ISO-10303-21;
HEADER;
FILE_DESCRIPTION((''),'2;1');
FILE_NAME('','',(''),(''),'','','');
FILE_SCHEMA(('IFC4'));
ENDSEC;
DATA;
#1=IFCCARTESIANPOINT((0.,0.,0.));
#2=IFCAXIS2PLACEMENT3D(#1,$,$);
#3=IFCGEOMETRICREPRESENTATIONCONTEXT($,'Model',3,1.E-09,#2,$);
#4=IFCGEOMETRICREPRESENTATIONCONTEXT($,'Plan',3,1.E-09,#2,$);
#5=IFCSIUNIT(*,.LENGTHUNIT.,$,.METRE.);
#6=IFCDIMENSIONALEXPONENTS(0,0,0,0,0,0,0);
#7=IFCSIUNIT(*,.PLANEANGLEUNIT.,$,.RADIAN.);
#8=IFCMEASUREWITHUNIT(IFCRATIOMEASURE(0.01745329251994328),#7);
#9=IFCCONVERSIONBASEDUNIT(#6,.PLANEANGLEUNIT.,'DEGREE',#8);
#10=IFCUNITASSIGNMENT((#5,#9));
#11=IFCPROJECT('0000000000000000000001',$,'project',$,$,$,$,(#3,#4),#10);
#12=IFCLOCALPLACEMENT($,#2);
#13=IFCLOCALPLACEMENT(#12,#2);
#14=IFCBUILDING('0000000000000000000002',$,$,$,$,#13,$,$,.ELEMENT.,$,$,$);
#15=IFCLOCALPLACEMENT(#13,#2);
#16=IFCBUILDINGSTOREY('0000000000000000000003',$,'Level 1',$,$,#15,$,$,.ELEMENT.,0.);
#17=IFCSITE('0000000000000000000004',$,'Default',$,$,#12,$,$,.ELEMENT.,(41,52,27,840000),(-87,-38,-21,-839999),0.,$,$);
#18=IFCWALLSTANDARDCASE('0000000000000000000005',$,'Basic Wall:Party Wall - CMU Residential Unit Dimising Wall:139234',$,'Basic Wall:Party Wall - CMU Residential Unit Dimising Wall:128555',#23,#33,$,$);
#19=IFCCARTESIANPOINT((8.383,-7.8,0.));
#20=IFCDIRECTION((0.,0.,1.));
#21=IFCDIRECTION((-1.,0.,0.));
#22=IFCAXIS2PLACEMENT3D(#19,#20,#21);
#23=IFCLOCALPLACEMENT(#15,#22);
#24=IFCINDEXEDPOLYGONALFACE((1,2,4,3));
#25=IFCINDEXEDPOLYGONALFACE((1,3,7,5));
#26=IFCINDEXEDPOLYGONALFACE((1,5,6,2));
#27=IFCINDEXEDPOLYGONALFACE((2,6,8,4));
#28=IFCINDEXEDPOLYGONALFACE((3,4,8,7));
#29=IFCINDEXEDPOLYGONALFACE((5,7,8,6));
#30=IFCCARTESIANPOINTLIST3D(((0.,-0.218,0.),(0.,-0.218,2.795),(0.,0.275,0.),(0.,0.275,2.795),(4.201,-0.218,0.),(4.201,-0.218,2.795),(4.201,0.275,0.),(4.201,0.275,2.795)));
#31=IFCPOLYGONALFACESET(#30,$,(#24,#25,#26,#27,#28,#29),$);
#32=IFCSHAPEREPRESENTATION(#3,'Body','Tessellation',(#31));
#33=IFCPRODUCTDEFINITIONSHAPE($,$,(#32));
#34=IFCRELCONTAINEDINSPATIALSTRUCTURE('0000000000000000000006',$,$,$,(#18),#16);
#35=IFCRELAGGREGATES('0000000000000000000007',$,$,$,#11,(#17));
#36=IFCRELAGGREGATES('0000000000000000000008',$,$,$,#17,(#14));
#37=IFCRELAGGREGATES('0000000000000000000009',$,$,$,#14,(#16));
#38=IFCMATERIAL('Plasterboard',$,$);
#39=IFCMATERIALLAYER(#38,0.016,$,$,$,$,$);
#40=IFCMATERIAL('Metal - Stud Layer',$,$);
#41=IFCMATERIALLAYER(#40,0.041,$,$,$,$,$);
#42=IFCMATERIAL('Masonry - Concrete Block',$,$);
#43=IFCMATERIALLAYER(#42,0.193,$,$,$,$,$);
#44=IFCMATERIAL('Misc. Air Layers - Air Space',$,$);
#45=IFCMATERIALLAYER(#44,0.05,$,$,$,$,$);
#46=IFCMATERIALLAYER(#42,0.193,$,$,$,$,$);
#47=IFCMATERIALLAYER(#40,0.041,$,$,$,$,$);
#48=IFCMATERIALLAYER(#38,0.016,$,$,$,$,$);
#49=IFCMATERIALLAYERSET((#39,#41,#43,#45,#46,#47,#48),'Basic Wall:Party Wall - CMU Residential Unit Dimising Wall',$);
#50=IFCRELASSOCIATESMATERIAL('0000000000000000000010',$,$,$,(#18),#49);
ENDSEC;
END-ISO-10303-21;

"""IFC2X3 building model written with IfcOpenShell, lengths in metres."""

from ifc_helpers import new_model, entity, si_unit, converted_unit, frame, frame_2d, origin, place, context, project, spatial, polyline, rectangle, extrude, clip, bounded_halfspace, material, layer, layer_set, layer_usage, element, save


model = new_model("IFC2X3")

# Units and contexts
model_context = context("Model", 3, precision=1e-09, world=origin())
plan_context = context("Plan", 3, precision=1e-09, world=origin())
ifc_project = project(units=[si_unit("LENGTHUNIT", "METRE"), converted_unit("PLANEANGLEUNIT", "DEGREE", entity("IfcRatioMeasure", 0.01745329251994328), si_unit("PLANEANGLEUNIT", "RADIAN"), dimensions=[0, 0, 0, 0, 0, 0, 0])], contexts=[model_context, plan_context])

# Site, building, storey
site_placement = place(None, origin())
site = spatial("IfcSite", under=ifc_project, at=site_placement, Name="Default", CompositionType="ELEMENT", RefLatitude=(41, 52, 27, 840000), RefLongitude=(-87, -38, -21, -839999), RefElevation=0.0)
building_placement = place(site_placement, origin())
building = spatial("IfcBuilding", under=site, at=building_placement, CompositionType="ELEMENT")
storey_placement = place(building_placement, origin())
storey = spatial("IfcBuildingStorey", under=building, at=storey_placement, Name="Level 1", CompositionType="ELEMENT", Elevation=0.0)

# Wall
ifc_material_1 = material(Name="Plasterboard")
ifc_layer_1 = layer(ifc_material_1, 0.016)
ifc_material_2 = material(Name="Metal - Stud Layer")
ifc_layer_2 = layer(ifc_material_2, 0.041)
ifc_material_3 = material(Name="Masonry - Concrete Block")
ifc_layer_3 = layer(ifc_material_3, 0.193)
ifc_material_4 = material(Name="Misc. Air Layers - Air Space")
ifc_layer_4 = layer(ifc_material_4, 0.05)
ifc_layer_5 = layer(ifc_material_3, 0.193)
ifc_layer_6 = layer(ifc_material_2, 0.041)
ifc_layer_7 = layer(ifc_material_1, 0.016)
ifc_layer_set_1 = layer_set([ifc_layer_1, ifc_layer_2, ifc_layer_3, ifc_layer_4, ifc_layer_5, ifc_layer_6, ifc_layer_7], Name="Basic Wall:Party Wall - CMU Residential Unit Dimising Wall")
ifc_layer_usage_1 = layer_usage(ifc_layer_set_1, "AXIS2", "NEGATIVE", 0.275)
wall_1_placement = place(storey_placement, frame((8.383, -7.8, 0.0), z_axis=(0.0, 0.0, 1.0), x_axis=(-1.0, 0.0, 0.0)))
element("IfcWallStandardCase", 1, at=wall_1_placement, inside=storey, material=ifc_layer_usage_1, Name="Basic Wall:Party Wall - CMU Residential Unit Dimising Wall:139234", ObjectType="Basic Wall:Party Wall - CMU Residential Unit Dimising Wall:128555", context=model_context, shape_type="Clipping", body=[
    clip(clip(extrude(rectangle(XDim=4.201, YDim=0.55, at=frame_2d((2.1005, 0.0), x_axis=(-1.0, 0.0))), origin(), (0.0, 0.0, 1.0), 2.795), bounded_halfspace(frame((0.0, -0.218, 2.795), z_axis=(0.0, 1.0, 0.0), x_axis=(-1.0, 0.0, 0.0)), True, frame((0.0, -0.218, 2.795), z_axis=(0.0, 1.0, 0.0), x_axis=(-1.0, 0.0, 0.0)), polyline([(0.0, 0.0), (-3.708, 0.0), (-4.201, 0.0), (-4.201, -2.795), (0.0, -2.795), (0.0, 0.0)]))), bounded_halfspace(frame((4.201, 0.275, 0.0), z_axis=(-1.0, 0.0, 0.0), x_axis=(0.0, -1.0, 0.0)), True, frame((4.201, 0.275, 0.0), z_axis=(-1.0, 0.0, 0.0), x_axis=(0.0, -1.0, 0.0)), polyline([(0.0, 0.0), (0.493, 0.0), (0.493, 2.795), (0.0, 2.795), (0.0, 0.0)]))),
])

save(model, "model.ifc")
